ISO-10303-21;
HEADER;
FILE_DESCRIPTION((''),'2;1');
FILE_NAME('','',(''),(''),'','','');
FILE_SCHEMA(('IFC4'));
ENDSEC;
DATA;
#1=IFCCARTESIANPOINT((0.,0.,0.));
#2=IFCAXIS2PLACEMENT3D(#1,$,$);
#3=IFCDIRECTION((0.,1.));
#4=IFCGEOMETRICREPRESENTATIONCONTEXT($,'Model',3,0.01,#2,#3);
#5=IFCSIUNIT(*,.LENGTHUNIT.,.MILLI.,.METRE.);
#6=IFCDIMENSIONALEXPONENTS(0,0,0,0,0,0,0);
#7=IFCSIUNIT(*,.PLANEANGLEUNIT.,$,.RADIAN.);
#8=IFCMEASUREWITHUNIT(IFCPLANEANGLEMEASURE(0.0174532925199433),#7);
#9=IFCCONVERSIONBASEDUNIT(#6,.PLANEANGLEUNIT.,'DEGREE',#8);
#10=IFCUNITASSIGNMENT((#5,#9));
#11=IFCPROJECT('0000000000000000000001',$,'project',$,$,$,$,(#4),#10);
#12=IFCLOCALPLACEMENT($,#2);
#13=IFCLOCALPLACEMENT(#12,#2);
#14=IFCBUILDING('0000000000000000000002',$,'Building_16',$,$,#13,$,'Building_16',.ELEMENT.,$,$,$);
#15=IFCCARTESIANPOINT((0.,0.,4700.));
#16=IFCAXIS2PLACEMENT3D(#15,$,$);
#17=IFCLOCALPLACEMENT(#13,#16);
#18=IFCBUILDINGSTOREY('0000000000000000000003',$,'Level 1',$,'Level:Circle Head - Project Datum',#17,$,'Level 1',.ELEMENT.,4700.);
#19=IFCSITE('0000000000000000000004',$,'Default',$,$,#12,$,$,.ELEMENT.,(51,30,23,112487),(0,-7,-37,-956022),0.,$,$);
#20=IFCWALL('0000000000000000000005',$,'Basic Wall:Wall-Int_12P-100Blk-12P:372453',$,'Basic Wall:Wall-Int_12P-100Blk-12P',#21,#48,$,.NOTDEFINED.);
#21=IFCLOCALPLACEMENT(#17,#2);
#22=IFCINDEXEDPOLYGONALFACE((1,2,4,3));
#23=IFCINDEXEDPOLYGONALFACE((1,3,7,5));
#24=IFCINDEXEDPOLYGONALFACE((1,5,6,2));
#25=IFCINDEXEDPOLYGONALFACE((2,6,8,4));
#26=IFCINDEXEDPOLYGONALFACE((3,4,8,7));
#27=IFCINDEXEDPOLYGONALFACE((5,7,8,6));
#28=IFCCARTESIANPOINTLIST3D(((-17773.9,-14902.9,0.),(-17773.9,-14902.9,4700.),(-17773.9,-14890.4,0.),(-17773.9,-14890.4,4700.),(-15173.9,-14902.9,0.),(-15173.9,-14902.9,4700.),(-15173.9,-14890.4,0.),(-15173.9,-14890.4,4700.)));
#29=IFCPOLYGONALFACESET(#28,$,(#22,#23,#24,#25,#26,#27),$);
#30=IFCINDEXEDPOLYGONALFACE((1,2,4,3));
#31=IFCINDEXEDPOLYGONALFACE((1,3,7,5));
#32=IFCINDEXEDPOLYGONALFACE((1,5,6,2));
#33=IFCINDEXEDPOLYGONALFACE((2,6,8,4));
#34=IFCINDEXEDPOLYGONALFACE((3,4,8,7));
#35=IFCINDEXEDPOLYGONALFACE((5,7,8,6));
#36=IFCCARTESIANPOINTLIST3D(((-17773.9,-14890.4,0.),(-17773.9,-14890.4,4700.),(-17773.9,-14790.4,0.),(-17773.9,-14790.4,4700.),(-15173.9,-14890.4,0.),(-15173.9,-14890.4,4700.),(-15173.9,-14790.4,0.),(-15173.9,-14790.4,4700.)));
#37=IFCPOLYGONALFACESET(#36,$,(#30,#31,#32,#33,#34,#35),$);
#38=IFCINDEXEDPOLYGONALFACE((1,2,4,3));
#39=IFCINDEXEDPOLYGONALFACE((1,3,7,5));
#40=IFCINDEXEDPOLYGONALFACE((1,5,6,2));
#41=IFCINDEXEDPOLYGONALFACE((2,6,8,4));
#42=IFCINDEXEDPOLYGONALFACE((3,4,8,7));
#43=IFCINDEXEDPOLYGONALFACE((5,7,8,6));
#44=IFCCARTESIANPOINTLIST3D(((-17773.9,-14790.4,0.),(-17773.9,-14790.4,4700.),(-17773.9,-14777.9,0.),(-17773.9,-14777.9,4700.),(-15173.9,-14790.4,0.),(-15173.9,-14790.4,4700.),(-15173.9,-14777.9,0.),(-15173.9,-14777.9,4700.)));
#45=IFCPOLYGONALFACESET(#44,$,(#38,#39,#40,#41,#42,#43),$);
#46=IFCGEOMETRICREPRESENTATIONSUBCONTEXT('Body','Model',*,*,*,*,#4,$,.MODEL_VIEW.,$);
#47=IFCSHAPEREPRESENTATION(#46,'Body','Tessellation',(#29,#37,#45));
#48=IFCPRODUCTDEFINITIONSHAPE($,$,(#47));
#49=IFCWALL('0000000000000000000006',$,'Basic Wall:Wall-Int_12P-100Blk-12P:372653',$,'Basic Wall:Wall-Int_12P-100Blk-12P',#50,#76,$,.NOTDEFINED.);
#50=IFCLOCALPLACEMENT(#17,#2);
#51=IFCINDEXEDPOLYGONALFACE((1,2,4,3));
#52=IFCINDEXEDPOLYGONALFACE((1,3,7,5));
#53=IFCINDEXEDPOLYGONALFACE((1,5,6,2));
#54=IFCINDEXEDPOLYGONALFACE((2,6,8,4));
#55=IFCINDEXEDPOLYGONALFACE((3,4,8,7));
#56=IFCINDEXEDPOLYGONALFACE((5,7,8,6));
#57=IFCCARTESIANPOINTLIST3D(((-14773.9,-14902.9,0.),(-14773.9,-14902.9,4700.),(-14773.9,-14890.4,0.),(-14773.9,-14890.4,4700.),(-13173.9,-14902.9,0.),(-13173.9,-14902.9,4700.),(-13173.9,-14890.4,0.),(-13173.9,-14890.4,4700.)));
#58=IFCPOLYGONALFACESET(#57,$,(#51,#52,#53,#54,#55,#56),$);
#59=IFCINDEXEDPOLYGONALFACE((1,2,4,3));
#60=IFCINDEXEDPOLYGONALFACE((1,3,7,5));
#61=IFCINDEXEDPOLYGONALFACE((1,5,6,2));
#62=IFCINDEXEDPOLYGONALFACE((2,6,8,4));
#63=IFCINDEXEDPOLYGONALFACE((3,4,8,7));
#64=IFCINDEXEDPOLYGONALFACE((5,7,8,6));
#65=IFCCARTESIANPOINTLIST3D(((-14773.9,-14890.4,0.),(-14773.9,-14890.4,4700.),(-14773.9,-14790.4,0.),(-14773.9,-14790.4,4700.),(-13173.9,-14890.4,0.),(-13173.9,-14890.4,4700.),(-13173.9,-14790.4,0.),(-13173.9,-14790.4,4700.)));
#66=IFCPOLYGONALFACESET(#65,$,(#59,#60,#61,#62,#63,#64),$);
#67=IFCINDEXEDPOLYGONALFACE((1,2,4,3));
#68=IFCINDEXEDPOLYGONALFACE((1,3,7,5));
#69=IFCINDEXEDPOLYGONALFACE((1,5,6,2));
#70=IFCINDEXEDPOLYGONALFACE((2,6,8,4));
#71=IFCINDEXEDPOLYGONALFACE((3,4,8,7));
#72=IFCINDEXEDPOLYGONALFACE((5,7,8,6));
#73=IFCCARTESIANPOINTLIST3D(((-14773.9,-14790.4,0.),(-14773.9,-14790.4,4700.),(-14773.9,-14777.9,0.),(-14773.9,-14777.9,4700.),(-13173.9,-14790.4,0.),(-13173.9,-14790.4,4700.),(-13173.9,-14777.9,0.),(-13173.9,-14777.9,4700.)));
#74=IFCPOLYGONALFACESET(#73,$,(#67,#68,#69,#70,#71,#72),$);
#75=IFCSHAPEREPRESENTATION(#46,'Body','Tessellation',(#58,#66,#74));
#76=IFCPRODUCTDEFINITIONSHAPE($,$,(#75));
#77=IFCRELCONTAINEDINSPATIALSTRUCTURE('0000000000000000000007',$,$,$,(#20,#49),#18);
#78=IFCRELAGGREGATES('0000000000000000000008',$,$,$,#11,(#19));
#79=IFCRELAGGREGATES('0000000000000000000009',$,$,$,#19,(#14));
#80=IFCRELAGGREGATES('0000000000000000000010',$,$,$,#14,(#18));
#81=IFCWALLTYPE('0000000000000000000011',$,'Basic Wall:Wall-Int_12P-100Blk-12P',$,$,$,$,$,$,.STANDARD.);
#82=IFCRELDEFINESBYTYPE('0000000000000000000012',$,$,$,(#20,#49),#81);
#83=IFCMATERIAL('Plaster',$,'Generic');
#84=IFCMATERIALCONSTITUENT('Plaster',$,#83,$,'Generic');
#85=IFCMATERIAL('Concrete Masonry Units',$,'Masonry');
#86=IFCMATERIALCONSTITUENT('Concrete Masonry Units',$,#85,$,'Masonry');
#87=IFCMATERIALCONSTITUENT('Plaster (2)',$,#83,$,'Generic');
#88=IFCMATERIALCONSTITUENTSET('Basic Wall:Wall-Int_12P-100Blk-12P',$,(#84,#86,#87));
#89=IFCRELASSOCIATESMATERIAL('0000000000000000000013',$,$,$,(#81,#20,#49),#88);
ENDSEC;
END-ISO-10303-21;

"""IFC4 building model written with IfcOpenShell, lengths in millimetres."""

from ifc_helpers import new_model, entity, si_unit, converted_unit, direction, frame, origin, place, context, subcontext, project, spatial, indexed_curve, outline, extrude, material, constituent, constituent_set, type_object, element, save


model = new_model("IFC4")

# Units and contexts
model_context = context("Model", 3, precision=0.01, world=origin(), true_north=direction((0.0, 1.0)))
body_context = subcontext(model_context, "Body", "Model", "MODEL_VIEW")
ifc_project = project(units=[si_unit("LENGTHUNIT", "METRE", prefix="MILLI"), converted_unit("PLANEANGLEUNIT", "DEGREE", entity("IfcPlaneAngleMeasure", 0.0174532925199433), si_unit("PLANEANGLEUNIT", "RADIAN"), dimensions=[0, 0, 0, 0, 0, 0, 0])], contexts=[model_context])

# Site, building, storey
site_placement = place(None, origin())
site = spatial("IfcSite", under=ifc_project, at=site_placement, Name="Default", CompositionType="ELEMENT", RefLatitude=(51, 30, 23, 112487), RefLongitude=(0, -7, -37, -956022), RefElevation=0.0)
building_placement = place(site_placement, origin())
building = spatial("IfcBuilding", under=site, at=building_placement, Name="Building_16", LongName="Building_16", CompositionType="ELEMENT")
storey_placement = place(building_placement, frame((0.0, 0.0, 4700.0)))
storey = spatial("IfcBuildingStorey", under=building, at=storey_placement, Name="Level 1", ObjectType="Level:Circle Head - Project Datum", LongName="Level 1", CompositionType="ELEMENT", Elevation=4700.0)

# Wall
ifc_material_1 = material(Name="Plaster", Category="Generic")
ifc_constituent_1 = constituent(ifc_material_1, Name="Plaster", Category="Generic")
ifc_material_2 = material(Name="Concrete Masonry Units", Category="Masonry")
ifc_constituent_2 = constituent(ifc_material_2, Name="Concrete Masonry Units", Category="Masonry")
ifc_constituent_3 = constituent(ifc_material_1, Name="Plaster (2)", Category="Generic")
ifc_constituent_set = constituent_set(constituents=[ifc_constituent_1, ifc_constituent_2, ifc_constituent_3], Name="Basic Wall:Wall-Int_12P-100Blk-12P")
wall_type = type_object("IfcWallType", Name="Basic Wall:Wall-Int_12P-100Blk-12P", PredefinedType="STANDARD", material=ifc_constituent_set)
wall_1_placement = place(storey_placement, frame((-17773.9, -14840.4, 0.0)))
element("IfcWall", 1, at=wall_1_placement, inside=storey, type_object=wall_type, material=ifc_constituent_set, Name="Basic Wall:Wall-Int_12P-100Blk-12P:372453", ObjectType="Basic Wall:Wall-Int_12P-100Blk-12P", PredefinedType="NOTDEFINED", context=body_context, shape_type="SweptSolid", body=[
    extrude(outline(indexed_curve([(-6.3, -1300.0), (6.2, -1300.0), (6.3, 1300.0), (-6.2, 1300.0), (-6.3, -1300.0)], self_intersect=False)), frame((1300.0, -56.2, 0.0), z_axis=(0.0, 0.0, 1.0), x_axis=(0.0, 1.0, 0.0)), (0.0, 0.0, 1.0), 4700.0),
    extrude(outline(indexed_curve([(-1300.0, -50.0), (1300.0, -50.0), (1300.0, 50.0), (-1300.0, 50.0), (-1300.0, -50.0)], self_intersect=False)), frame((1300.0, 0.0, 0.0)), (0.0, 0.0, 1.0), 4700.0),
    extrude(outline(indexed_curve([(-6.3, -1300.0), (6.2, -1300.0), (6.3, 1300.0), (-6.2, 1300.0), (-6.3, -1300.0)], self_intersect=False)), frame((1300.0, 56.3, 0.0), z_axis=(0.0, 0.0, 1.0), x_axis=(0.0, -1.0, 0.0)), (0.0, 0.0, 1.0), 4700.0),
])

# Wall
wall_2_placement = place(storey_placement, frame((-14773.9, -14840.4, 0.0)))
element("IfcWall", 2, at=wall_2_placement, inside=storey, type_object=wall_type, material=ifc_constituent_set, Name="Basic Wall:Wall-Int_12P-100Blk-12P:372653", ObjectType="Basic Wall:Wall-Int_12P-100Blk-12P", PredefinedType="NOTDEFINED", context=body_context, shape_type="SweptSolid", body=[
    extrude(outline(indexed_curve([(-6.3, -800.0), (6.2, -800.0), (6.3, 800.0), (-6.2, 800.0), (-6.3, -800.0)], self_intersect=False)), frame((800.0, -56.2, 0.0), z_axis=(0.0, 0.0, 1.0), x_axis=(0.0, 1.0, 0.0)), (0.0, 0.0, 1.0), 4700.0),
    extrude(outline(indexed_curve([(-800.0, -50.0), (800.0, -50.0), (800.0, 50.0), (-800.0, 50.0), (-800.0, -50.0)], self_intersect=False)), frame((800.0, 0.0, 0.0)), (0.0, 0.0, 1.0), 4700.0),
    extrude(outline(indexed_curve([(-6.3, -800.0), (6.2, -800.0), (6.3, 800.0), (-6.2, 800.0), (-6.3, -800.0)], self_intersect=False)), frame((800.0, 56.3, 0.0), z_axis=(0.0, 0.0, 1.0), x_axis=(0.0, -1.0, 0.0)), (0.0, 0.0, 1.0), 4700.0),
])

save(model, "model.ifc")
